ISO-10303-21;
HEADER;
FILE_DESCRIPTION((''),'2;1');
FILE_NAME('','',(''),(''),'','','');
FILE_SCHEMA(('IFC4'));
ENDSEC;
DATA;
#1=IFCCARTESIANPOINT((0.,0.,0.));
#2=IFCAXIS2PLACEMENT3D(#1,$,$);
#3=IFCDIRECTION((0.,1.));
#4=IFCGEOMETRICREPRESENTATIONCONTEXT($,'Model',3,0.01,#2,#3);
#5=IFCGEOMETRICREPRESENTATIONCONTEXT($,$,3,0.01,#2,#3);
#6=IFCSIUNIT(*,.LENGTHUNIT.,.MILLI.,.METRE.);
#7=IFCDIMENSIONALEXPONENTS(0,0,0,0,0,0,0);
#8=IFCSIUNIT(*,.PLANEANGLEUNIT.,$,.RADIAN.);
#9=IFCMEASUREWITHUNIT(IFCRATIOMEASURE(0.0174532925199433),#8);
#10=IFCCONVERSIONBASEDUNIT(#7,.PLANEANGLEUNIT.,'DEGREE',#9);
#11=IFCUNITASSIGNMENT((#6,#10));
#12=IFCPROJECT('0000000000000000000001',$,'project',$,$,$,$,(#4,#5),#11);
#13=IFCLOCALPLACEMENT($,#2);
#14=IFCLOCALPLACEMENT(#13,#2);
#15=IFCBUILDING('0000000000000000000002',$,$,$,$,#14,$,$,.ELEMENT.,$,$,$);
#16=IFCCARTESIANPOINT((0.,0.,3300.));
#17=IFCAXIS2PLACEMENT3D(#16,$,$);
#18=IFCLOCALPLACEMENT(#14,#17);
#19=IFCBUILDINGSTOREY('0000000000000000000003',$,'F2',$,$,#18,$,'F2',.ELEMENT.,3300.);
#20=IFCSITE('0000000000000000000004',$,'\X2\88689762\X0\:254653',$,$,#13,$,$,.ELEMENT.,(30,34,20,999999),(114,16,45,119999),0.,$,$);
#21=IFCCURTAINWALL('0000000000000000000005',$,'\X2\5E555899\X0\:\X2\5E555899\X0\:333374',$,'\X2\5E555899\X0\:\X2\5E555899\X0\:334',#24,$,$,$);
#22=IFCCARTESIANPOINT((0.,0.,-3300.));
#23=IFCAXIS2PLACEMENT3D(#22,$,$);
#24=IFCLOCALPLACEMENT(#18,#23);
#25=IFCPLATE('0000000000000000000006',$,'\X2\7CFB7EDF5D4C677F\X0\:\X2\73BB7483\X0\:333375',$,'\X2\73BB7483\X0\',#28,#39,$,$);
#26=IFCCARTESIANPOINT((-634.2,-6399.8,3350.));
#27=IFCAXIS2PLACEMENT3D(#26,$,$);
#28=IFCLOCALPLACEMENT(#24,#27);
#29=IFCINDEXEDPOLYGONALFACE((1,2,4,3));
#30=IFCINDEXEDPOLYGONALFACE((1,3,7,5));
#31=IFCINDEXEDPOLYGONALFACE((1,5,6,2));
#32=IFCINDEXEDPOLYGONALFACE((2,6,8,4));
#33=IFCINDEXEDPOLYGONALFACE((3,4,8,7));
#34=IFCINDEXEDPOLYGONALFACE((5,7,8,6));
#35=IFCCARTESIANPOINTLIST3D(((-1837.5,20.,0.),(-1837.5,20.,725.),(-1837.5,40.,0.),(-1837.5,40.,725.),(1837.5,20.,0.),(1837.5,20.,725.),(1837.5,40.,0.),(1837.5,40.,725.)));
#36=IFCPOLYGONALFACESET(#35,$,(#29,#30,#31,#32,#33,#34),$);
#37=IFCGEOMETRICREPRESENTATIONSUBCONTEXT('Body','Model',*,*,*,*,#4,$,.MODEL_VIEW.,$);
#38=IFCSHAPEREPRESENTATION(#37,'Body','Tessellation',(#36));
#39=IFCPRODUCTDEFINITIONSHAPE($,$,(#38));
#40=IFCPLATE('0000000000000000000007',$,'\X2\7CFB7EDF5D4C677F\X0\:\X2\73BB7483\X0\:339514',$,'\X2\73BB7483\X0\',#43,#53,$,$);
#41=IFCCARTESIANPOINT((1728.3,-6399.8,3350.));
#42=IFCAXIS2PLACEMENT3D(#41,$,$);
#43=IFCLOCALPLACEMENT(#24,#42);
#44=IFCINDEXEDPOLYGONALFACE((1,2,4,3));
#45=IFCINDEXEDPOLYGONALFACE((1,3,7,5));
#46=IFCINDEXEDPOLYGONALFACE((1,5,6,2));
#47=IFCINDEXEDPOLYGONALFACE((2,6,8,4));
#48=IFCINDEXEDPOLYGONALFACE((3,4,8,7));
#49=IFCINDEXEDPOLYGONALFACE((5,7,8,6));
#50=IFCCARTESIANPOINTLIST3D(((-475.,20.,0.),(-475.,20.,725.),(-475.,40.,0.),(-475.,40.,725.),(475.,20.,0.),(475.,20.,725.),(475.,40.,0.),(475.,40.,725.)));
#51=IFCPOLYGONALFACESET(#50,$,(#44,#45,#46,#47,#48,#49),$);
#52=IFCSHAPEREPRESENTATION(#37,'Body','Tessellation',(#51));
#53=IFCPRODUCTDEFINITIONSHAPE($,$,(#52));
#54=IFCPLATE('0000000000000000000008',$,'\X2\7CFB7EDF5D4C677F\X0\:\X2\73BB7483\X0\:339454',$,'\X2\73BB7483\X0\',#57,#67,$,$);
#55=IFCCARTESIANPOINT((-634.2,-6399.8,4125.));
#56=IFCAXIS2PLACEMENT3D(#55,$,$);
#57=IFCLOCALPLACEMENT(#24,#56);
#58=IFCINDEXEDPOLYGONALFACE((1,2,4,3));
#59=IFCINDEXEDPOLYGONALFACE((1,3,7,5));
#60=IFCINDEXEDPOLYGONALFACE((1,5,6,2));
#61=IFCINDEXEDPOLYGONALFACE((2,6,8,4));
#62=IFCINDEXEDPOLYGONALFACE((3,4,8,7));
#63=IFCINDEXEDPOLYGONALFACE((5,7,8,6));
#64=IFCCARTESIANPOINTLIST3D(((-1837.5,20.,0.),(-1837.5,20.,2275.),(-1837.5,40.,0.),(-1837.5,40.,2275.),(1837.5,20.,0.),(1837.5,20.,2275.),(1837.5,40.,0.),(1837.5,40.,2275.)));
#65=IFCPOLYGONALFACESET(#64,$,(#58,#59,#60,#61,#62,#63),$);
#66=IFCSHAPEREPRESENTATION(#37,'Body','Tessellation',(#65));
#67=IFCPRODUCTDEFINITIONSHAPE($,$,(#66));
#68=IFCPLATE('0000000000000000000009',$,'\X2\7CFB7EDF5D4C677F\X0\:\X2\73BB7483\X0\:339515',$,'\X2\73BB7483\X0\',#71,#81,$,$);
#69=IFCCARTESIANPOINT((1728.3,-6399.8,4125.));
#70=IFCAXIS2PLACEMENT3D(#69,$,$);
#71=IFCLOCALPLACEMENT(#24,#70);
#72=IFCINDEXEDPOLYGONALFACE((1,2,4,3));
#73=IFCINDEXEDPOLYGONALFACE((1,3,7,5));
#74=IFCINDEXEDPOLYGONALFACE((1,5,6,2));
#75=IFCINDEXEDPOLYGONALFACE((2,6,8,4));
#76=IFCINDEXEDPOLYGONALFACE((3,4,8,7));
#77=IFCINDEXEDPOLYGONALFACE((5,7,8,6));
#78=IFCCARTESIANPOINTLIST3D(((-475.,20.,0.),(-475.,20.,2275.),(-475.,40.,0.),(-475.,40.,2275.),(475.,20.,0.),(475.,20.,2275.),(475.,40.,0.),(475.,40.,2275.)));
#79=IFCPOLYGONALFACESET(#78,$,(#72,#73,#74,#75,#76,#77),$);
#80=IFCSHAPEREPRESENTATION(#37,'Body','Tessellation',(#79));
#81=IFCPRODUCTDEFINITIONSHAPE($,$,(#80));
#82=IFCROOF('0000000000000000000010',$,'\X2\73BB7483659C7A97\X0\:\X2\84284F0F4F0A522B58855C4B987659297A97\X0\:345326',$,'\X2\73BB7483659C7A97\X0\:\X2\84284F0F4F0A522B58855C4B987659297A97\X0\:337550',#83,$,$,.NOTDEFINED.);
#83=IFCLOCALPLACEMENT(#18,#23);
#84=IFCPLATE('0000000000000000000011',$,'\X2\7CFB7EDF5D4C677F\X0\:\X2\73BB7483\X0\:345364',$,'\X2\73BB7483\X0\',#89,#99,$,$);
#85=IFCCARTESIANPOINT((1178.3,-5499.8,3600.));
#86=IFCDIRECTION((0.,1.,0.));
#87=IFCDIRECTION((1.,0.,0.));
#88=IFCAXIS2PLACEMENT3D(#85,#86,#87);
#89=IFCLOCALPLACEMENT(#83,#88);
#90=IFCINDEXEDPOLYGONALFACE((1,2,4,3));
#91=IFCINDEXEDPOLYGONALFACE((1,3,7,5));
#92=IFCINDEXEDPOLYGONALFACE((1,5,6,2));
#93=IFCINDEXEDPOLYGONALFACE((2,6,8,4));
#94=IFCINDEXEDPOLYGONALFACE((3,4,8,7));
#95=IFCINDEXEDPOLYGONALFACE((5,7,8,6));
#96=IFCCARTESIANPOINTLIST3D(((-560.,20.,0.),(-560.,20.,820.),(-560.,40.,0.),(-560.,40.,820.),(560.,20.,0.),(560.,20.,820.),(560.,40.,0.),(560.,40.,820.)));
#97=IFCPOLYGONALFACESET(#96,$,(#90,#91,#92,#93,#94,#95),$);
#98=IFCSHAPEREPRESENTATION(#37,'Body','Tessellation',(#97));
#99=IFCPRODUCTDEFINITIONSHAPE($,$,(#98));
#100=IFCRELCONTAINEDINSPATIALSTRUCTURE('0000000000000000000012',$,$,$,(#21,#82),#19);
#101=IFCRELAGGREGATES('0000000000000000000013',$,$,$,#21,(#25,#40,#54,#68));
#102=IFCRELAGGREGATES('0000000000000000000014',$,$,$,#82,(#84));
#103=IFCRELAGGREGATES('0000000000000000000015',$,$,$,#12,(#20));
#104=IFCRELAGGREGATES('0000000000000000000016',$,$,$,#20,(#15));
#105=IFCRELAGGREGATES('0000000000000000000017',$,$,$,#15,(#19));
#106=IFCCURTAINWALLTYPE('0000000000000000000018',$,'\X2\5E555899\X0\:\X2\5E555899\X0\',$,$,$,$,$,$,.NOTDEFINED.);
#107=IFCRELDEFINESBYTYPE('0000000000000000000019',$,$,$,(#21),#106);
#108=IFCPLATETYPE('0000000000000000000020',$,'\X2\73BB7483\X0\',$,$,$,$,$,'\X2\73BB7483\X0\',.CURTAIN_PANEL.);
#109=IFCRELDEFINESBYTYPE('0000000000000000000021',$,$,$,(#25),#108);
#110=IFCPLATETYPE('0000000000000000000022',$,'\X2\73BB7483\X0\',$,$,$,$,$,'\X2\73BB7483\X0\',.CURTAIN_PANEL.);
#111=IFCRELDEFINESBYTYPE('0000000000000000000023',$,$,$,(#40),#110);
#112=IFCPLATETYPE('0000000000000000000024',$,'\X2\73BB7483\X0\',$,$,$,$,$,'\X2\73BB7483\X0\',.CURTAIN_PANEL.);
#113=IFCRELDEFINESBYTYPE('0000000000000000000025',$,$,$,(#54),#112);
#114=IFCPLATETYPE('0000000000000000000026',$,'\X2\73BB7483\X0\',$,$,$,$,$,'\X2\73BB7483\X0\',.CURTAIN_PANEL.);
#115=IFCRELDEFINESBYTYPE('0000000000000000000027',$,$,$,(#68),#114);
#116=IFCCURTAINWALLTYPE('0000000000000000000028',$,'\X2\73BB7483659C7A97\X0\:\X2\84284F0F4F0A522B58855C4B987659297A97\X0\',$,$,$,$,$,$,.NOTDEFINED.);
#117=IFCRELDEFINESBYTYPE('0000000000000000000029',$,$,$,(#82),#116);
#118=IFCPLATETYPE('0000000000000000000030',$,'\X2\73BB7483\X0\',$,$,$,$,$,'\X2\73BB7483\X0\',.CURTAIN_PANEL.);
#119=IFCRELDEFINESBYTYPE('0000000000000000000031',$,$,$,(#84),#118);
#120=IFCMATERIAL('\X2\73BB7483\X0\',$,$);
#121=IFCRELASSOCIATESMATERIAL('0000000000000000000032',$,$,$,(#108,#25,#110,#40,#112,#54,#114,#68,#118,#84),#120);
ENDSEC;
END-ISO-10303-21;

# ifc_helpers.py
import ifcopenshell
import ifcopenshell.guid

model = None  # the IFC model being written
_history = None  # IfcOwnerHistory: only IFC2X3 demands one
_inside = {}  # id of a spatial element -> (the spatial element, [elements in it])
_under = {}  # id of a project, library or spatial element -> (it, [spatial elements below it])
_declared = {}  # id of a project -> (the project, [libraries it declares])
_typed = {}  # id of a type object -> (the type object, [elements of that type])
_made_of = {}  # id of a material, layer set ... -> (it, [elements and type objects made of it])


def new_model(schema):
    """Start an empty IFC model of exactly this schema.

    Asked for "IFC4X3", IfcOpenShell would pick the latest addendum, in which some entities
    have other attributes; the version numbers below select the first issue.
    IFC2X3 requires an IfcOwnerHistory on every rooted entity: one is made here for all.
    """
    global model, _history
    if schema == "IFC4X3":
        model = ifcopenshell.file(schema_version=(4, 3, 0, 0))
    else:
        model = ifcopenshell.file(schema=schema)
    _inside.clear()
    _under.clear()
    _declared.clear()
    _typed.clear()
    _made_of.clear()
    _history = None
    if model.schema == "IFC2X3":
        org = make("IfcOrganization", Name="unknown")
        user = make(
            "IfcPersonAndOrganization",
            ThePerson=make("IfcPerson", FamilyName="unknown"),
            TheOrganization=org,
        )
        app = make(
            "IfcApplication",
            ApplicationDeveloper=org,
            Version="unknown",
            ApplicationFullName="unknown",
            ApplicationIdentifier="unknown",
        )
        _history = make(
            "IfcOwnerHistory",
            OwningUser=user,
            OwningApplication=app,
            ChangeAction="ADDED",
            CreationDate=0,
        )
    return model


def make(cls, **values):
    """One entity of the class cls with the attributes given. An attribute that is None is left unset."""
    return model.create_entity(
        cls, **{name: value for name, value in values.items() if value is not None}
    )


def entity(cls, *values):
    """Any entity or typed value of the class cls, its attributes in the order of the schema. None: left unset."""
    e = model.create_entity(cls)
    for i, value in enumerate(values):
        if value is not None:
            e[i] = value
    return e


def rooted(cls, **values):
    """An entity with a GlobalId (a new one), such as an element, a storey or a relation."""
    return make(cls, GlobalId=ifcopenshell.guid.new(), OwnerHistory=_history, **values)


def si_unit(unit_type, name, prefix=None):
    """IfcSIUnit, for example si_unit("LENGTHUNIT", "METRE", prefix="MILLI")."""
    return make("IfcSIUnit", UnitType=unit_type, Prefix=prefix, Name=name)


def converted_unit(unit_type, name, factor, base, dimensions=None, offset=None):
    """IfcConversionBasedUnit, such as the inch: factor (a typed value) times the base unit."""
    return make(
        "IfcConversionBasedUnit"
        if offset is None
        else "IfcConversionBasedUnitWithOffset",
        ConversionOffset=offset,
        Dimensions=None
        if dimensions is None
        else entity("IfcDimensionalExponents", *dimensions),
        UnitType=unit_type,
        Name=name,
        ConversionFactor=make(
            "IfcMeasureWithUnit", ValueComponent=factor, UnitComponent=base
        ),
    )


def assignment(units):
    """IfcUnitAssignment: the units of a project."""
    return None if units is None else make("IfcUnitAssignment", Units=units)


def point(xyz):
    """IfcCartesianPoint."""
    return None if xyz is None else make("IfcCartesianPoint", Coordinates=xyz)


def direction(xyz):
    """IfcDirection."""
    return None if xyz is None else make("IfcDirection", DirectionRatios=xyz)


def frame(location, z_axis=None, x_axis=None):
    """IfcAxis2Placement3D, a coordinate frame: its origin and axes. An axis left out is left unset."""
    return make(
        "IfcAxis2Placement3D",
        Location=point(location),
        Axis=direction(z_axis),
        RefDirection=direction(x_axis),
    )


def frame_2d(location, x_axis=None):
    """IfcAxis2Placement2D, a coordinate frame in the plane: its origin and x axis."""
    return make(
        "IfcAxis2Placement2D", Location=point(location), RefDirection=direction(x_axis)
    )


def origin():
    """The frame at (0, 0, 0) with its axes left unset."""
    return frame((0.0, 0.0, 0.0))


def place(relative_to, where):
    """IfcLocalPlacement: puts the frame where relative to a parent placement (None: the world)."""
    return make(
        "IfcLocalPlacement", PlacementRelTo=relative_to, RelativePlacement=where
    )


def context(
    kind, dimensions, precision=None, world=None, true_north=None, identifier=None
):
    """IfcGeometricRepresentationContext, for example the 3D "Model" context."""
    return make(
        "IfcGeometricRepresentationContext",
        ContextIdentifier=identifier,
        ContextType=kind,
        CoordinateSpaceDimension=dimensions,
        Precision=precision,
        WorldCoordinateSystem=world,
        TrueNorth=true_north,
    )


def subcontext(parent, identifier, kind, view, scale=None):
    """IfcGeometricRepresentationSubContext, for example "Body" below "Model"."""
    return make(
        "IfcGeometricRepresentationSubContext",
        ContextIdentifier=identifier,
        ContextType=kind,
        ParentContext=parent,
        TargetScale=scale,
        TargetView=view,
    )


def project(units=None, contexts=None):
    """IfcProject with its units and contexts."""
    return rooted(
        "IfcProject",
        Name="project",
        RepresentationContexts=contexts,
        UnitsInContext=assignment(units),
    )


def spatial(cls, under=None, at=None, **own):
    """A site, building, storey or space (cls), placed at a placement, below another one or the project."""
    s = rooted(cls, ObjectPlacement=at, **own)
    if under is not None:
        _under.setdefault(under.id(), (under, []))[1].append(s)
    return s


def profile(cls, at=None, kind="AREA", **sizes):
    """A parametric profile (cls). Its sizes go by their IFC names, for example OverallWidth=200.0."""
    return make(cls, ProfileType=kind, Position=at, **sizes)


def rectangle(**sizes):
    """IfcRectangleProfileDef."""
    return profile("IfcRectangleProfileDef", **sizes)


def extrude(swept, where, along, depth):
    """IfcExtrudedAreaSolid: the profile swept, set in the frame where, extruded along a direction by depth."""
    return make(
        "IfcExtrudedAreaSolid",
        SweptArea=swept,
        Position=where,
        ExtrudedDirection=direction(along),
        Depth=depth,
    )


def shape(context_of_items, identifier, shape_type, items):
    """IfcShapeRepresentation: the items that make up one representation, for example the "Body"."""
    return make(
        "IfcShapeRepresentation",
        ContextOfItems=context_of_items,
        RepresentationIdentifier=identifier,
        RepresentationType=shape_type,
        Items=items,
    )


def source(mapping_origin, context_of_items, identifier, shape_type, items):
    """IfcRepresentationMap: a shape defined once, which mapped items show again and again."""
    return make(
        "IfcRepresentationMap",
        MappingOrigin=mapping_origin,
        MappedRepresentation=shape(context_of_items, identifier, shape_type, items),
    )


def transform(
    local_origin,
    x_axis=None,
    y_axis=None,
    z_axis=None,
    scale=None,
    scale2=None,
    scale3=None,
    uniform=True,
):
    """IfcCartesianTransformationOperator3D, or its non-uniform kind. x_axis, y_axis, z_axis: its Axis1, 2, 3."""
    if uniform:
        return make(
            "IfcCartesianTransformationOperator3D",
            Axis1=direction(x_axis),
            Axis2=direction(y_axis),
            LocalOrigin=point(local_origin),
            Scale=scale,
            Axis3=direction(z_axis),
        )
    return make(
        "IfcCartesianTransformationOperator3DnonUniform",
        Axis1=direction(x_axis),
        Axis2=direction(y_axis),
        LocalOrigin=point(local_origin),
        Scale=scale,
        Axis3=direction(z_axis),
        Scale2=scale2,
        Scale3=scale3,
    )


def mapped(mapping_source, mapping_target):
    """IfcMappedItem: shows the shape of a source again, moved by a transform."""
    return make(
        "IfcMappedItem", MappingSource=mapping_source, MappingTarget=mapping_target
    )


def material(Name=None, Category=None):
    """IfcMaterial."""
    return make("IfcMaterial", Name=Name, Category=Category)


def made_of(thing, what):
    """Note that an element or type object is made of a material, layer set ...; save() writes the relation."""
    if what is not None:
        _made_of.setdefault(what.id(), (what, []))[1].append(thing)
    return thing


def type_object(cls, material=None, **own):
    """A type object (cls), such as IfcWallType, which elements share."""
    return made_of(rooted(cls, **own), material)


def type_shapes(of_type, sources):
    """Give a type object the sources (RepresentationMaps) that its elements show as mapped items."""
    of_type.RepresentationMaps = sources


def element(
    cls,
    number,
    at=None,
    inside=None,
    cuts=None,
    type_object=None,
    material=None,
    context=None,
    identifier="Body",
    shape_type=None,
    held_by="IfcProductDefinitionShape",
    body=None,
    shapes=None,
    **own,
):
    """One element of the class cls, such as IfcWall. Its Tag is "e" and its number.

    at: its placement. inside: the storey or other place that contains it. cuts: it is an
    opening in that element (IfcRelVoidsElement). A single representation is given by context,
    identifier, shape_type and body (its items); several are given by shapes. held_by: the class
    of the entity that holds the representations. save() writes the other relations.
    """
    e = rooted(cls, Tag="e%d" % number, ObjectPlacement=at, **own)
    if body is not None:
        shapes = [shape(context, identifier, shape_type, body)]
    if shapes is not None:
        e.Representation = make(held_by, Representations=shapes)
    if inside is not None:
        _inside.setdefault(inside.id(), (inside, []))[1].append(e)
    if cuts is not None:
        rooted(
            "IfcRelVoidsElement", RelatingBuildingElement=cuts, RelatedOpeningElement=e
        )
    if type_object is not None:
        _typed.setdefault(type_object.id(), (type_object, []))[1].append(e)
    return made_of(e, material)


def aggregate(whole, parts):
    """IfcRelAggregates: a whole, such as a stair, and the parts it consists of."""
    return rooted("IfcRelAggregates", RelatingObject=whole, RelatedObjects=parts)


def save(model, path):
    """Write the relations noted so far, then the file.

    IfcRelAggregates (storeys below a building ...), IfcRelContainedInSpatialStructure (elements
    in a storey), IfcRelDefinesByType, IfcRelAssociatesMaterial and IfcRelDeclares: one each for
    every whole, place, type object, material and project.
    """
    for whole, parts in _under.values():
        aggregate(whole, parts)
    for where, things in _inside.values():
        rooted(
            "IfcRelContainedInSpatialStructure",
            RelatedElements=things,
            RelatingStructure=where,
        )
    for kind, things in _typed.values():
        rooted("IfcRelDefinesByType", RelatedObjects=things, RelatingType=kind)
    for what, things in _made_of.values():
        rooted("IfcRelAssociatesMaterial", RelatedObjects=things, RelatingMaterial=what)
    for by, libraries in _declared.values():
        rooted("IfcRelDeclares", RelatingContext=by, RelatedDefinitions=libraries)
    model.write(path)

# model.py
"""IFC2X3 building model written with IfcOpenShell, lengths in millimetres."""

from ifc_helpers import new_model, entity, si_unit, converted_unit, direction, frame, frame_2d, origin, place, context, subcontext, project, spatial, rectangle, extrude, source, transform, mapped, material, type_object, type_shapes, element, aggregate, save


model = new_model("IFC2X3")

# Units and contexts
model_context = context("Model", 3, precision=0.01, world=origin(), true_north=direction((0.0, 1.0)))
context_of_model = context(None, 3, precision=0.01, world=origin(), true_north=direction((0.0, 1.0)))
body_context = subcontext(model_context, "Body", "Model", "MODEL_VIEW")
ifc_project = project(units=[si_unit("LENGTHUNIT", "METRE", prefix="MILLI"), converted_unit("PLANEANGLEUNIT", "DEGREE", entity("IfcRatioMeasure", 0.0174532925199433), si_unit("PLANEANGLEUNIT", "RADIAN"), dimensions=[0, 0, 0, 0, 0, 0, 0])], contexts=[model_context, context_of_model])

# Site, building, storey
site_placement = place(None, origin())
site = spatial("IfcSite", under=ifc_project, at=site_placement, Name="表面:254653", CompositionType="ELEMENT", RefLatitude=(30, 34, 20, 999999), RefLongitude=(114, 16, 45, 119999), RefElevation=0.0)
building_placement = place(site_placement, origin())
building = spatial("IfcBuilding", under=site, at=building_placement, CompositionType="ELEMENT")
storey_placement = place(building_placement, frame((0.0, 0.0, 3300.0)))
storey = spatial("IfcBuildingStorey", under=building, at=storey_placement, Name="F2", LongName="F2", CompositionType="ELEMENT", Elevation=3300.0)

# Shared definitions
ifc_material_1 = material(Name="玻璃")

# Curtain wall, plates
curtain_wall_type_1 = type_object("IfcCurtainWallType", Name="幕墙:幕墙", PredefinedType="NOTDEFINED")
curtain_wall_1_placement = place(storey_placement, frame((0.0, 0.0, -3300.0)))
curtain_wall_1 = element("IfcCurtainWall", 1, at=curtain_wall_1_placement, inside=storey, type_object=curtain_wall_type_1, Name="幕墙:幕墙:333374", ObjectType="幕墙:幕墙:334")
plate_type_1 = type_object("IfcPlateType", Name="玻璃", ElementType="玻璃", PredefinedType="CURTAIN_PANEL", material=ifc_material_1)
shared_shape_1 = source(origin(), body_context, "Body", "SweptSolid", [
    extrude(rectangle(XDim=20.0, YDim=3675.0, at=frame_2d((0.0, 0.0), x_axis=(1.0, 0.0))), frame((0.0, 30.0, 0.0), z_axis=(0.0, 0.0, 1.0), x_axis=(0.0, 1.0, 0.0)), (0.0, 0.0, 1.0), 725.0),
])
type_shapes(plate_type_1, [shared_shape_1])
plate_1_placement = place(curtain_wall_1_placement, frame((-634.2, -6399.8, 3350.0)))
plate_1 = element("IfcPlate", 2, at=plate_1_placement, type_object=plate_type_1, material=ifc_material_1, Name="系统嵌板:玻璃:333375", ObjectType="玻璃", context=body_context, shape_type="MappedRepresentation", body=[
    mapped(shared_shape_1, transform((0.0, 0.0, 0.0), scale=1.0)),
])
plate_type_2 = type_object("IfcPlateType", Name="玻璃", ElementType="玻璃", PredefinedType="CURTAIN_PANEL", material=ifc_material_1)
shared_shape_2 = source(origin(), body_context, "Body", "SweptSolid", [
    extrude(rectangle(XDim=20.0, YDim=950.0, at=frame_2d((0.0, 0.0), x_axis=(1.0, 0.0))), frame((0.0, 30.0, 0.0), z_axis=(0.0, 0.0, 1.0), x_axis=(0.0, 1.0, 0.0)), (0.0, 0.0, 1.0), 725.0),
])
type_shapes(plate_type_2, [shared_shape_2])
plate_2_placement = place(curtain_wall_1_placement, frame((1728.3, -6399.8, 3350.0)))
plate_2 = element("IfcPlate", 3, at=plate_2_placement, type_object=plate_type_2, material=ifc_material_1, Name="系统嵌板:玻璃:339514", ObjectType="玻璃", context=body_context, shape_type="MappedRepresentation", body=[
    mapped(shared_shape_2, transform((0.0, 0.0, 0.0), scale=1.0)),
])
plate_type_3 = type_object("IfcPlateType", Name="玻璃", ElementType="玻璃", PredefinedType="CURTAIN_PANEL", material=ifc_material_1)
shared_shape_3 = source(origin(), body_context, "Body", "SweptSolid", [
    extrude(rectangle(XDim=20.0, YDim=3675.0, at=frame_2d((0.0, 0.0), x_axis=(1.0, 0.0))), frame((0.0, 30.0, 0.0), z_axis=(0.0, 0.0, 1.0), x_axis=(0.0, 1.0, 0.0)), (0.0, 0.0, 1.0), 2275.0),
])
type_shapes(plate_type_3, [shared_shape_3])
plate_3_placement = place(curtain_wall_1_placement, frame((-634.2, -6399.8, 4125.0)))
plate_3 = element("IfcPlate", 4, at=plate_3_placement, type_object=plate_type_3, material=ifc_material_1, Name="系统嵌板:玻璃:339454", ObjectType="玻璃", context=body_context, shape_type="MappedRepresentation", body=[
    mapped(shared_shape_3, transform((0.0, 0.0, 0.0), scale=1.0)),
])
plate_type_4 = type_object("IfcPlateType", Name="玻璃", ElementType="玻璃", PredefinedType="CURTAIN_PANEL", material=ifc_material_1)
shared_shape_4 = source(origin(), body_context, "Body", "SweptSolid", [
    extrude(rectangle(XDim=20.0, YDim=950.0, at=frame_2d((0.0, 0.0), x_axis=(1.0, 0.0))), frame((0.0, 30.0, 0.0), z_axis=(0.0, 0.0, 1.0), x_axis=(0.0, 1.0, 0.0)), (0.0, 0.0, 1.0), 2275.0),
])
type_shapes(plate_type_4, [shared_shape_4])
plate_4_placement = place(curtain_wall_1_placement, frame((1728.3, -6399.8, 4125.0)))
plate_4 = element("IfcPlate", 5, at=plate_4_placement, type_object=plate_type_4, material=ifc_material_1, Name="系统嵌板:玻璃:339515", ObjectType="玻璃", context=body_context, shape_type="MappedRepresentation", body=[
    mapped(shared_shape_4, transform((0.0, 0.0, 0.0), scale=1.0)),
])
aggregate(curtain_wall_1, [plate_1, plate_2, plate_3, plate_4])

# Roof, plate
curtain_wall_type_2 = type_object("IfcCurtainWallType", Name="玻璃斜窗:萨伏伊别墅屋顶天窗", PredefinedType="NOTDEFINED")
roof_placement = place(storey_placement, frame((0.0, 0.0, -3300.0)))
roof = element("IfcRoof", 6, at=roof_placement, inside=storey, type_object=curtain_wall_type_2, Name="玻璃斜窗:萨伏伊别墅屋顶天窗:345326", ObjectType="玻璃斜窗:萨伏伊别墅屋顶天窗:337550", ShapeType="NOTDEFINED")
plate_type_5 = type_object("IfcPlateType", Name="玻璃", ElementType="玻璃", PredefinedType="CURTAIN_PANEL", material=ifc_material_1)
shared_shape_5 = source(origin(), body_context, "Body", "SweptSolid", [
    extrude(rectangle(XDim=20.0, YDim=1120.0, at=frame_2d((0.0, 0.0), x_axis=(1.0, 0.0))), frame((0.0, 30.0, 0.0), z_axis=(0.0, 0.0, 1.0), x_axis=(0.0, 1.0, 0.0)), (0.0, 0.0, 1.0), 820.0),
])
type_shapes(plate_type_5, [shared_shape_5])
plate_5_placement = place(roof_placement, frame((1178.3, -5499.8, 3600.0), z_axis=(0.0, 1.0, 0.0), x_axis=(1.0, 0.0, 0.0)))
plate_5 = element("IfcPlate", 7, at=plate_5_placement, type_object=plate_type_5, material=ifc_material_1, Name="系统嵌板:玻璃:345364", ObjectType="玻璃", context=body_context, shape_type="MappedRepresentation", body=[
    mapped(shared_shape_5, transform((0.0, 0.0, 0.0), scale=1.0)),
])
aggregate(roof, [plate_5])

save(model, "model.ifc")
